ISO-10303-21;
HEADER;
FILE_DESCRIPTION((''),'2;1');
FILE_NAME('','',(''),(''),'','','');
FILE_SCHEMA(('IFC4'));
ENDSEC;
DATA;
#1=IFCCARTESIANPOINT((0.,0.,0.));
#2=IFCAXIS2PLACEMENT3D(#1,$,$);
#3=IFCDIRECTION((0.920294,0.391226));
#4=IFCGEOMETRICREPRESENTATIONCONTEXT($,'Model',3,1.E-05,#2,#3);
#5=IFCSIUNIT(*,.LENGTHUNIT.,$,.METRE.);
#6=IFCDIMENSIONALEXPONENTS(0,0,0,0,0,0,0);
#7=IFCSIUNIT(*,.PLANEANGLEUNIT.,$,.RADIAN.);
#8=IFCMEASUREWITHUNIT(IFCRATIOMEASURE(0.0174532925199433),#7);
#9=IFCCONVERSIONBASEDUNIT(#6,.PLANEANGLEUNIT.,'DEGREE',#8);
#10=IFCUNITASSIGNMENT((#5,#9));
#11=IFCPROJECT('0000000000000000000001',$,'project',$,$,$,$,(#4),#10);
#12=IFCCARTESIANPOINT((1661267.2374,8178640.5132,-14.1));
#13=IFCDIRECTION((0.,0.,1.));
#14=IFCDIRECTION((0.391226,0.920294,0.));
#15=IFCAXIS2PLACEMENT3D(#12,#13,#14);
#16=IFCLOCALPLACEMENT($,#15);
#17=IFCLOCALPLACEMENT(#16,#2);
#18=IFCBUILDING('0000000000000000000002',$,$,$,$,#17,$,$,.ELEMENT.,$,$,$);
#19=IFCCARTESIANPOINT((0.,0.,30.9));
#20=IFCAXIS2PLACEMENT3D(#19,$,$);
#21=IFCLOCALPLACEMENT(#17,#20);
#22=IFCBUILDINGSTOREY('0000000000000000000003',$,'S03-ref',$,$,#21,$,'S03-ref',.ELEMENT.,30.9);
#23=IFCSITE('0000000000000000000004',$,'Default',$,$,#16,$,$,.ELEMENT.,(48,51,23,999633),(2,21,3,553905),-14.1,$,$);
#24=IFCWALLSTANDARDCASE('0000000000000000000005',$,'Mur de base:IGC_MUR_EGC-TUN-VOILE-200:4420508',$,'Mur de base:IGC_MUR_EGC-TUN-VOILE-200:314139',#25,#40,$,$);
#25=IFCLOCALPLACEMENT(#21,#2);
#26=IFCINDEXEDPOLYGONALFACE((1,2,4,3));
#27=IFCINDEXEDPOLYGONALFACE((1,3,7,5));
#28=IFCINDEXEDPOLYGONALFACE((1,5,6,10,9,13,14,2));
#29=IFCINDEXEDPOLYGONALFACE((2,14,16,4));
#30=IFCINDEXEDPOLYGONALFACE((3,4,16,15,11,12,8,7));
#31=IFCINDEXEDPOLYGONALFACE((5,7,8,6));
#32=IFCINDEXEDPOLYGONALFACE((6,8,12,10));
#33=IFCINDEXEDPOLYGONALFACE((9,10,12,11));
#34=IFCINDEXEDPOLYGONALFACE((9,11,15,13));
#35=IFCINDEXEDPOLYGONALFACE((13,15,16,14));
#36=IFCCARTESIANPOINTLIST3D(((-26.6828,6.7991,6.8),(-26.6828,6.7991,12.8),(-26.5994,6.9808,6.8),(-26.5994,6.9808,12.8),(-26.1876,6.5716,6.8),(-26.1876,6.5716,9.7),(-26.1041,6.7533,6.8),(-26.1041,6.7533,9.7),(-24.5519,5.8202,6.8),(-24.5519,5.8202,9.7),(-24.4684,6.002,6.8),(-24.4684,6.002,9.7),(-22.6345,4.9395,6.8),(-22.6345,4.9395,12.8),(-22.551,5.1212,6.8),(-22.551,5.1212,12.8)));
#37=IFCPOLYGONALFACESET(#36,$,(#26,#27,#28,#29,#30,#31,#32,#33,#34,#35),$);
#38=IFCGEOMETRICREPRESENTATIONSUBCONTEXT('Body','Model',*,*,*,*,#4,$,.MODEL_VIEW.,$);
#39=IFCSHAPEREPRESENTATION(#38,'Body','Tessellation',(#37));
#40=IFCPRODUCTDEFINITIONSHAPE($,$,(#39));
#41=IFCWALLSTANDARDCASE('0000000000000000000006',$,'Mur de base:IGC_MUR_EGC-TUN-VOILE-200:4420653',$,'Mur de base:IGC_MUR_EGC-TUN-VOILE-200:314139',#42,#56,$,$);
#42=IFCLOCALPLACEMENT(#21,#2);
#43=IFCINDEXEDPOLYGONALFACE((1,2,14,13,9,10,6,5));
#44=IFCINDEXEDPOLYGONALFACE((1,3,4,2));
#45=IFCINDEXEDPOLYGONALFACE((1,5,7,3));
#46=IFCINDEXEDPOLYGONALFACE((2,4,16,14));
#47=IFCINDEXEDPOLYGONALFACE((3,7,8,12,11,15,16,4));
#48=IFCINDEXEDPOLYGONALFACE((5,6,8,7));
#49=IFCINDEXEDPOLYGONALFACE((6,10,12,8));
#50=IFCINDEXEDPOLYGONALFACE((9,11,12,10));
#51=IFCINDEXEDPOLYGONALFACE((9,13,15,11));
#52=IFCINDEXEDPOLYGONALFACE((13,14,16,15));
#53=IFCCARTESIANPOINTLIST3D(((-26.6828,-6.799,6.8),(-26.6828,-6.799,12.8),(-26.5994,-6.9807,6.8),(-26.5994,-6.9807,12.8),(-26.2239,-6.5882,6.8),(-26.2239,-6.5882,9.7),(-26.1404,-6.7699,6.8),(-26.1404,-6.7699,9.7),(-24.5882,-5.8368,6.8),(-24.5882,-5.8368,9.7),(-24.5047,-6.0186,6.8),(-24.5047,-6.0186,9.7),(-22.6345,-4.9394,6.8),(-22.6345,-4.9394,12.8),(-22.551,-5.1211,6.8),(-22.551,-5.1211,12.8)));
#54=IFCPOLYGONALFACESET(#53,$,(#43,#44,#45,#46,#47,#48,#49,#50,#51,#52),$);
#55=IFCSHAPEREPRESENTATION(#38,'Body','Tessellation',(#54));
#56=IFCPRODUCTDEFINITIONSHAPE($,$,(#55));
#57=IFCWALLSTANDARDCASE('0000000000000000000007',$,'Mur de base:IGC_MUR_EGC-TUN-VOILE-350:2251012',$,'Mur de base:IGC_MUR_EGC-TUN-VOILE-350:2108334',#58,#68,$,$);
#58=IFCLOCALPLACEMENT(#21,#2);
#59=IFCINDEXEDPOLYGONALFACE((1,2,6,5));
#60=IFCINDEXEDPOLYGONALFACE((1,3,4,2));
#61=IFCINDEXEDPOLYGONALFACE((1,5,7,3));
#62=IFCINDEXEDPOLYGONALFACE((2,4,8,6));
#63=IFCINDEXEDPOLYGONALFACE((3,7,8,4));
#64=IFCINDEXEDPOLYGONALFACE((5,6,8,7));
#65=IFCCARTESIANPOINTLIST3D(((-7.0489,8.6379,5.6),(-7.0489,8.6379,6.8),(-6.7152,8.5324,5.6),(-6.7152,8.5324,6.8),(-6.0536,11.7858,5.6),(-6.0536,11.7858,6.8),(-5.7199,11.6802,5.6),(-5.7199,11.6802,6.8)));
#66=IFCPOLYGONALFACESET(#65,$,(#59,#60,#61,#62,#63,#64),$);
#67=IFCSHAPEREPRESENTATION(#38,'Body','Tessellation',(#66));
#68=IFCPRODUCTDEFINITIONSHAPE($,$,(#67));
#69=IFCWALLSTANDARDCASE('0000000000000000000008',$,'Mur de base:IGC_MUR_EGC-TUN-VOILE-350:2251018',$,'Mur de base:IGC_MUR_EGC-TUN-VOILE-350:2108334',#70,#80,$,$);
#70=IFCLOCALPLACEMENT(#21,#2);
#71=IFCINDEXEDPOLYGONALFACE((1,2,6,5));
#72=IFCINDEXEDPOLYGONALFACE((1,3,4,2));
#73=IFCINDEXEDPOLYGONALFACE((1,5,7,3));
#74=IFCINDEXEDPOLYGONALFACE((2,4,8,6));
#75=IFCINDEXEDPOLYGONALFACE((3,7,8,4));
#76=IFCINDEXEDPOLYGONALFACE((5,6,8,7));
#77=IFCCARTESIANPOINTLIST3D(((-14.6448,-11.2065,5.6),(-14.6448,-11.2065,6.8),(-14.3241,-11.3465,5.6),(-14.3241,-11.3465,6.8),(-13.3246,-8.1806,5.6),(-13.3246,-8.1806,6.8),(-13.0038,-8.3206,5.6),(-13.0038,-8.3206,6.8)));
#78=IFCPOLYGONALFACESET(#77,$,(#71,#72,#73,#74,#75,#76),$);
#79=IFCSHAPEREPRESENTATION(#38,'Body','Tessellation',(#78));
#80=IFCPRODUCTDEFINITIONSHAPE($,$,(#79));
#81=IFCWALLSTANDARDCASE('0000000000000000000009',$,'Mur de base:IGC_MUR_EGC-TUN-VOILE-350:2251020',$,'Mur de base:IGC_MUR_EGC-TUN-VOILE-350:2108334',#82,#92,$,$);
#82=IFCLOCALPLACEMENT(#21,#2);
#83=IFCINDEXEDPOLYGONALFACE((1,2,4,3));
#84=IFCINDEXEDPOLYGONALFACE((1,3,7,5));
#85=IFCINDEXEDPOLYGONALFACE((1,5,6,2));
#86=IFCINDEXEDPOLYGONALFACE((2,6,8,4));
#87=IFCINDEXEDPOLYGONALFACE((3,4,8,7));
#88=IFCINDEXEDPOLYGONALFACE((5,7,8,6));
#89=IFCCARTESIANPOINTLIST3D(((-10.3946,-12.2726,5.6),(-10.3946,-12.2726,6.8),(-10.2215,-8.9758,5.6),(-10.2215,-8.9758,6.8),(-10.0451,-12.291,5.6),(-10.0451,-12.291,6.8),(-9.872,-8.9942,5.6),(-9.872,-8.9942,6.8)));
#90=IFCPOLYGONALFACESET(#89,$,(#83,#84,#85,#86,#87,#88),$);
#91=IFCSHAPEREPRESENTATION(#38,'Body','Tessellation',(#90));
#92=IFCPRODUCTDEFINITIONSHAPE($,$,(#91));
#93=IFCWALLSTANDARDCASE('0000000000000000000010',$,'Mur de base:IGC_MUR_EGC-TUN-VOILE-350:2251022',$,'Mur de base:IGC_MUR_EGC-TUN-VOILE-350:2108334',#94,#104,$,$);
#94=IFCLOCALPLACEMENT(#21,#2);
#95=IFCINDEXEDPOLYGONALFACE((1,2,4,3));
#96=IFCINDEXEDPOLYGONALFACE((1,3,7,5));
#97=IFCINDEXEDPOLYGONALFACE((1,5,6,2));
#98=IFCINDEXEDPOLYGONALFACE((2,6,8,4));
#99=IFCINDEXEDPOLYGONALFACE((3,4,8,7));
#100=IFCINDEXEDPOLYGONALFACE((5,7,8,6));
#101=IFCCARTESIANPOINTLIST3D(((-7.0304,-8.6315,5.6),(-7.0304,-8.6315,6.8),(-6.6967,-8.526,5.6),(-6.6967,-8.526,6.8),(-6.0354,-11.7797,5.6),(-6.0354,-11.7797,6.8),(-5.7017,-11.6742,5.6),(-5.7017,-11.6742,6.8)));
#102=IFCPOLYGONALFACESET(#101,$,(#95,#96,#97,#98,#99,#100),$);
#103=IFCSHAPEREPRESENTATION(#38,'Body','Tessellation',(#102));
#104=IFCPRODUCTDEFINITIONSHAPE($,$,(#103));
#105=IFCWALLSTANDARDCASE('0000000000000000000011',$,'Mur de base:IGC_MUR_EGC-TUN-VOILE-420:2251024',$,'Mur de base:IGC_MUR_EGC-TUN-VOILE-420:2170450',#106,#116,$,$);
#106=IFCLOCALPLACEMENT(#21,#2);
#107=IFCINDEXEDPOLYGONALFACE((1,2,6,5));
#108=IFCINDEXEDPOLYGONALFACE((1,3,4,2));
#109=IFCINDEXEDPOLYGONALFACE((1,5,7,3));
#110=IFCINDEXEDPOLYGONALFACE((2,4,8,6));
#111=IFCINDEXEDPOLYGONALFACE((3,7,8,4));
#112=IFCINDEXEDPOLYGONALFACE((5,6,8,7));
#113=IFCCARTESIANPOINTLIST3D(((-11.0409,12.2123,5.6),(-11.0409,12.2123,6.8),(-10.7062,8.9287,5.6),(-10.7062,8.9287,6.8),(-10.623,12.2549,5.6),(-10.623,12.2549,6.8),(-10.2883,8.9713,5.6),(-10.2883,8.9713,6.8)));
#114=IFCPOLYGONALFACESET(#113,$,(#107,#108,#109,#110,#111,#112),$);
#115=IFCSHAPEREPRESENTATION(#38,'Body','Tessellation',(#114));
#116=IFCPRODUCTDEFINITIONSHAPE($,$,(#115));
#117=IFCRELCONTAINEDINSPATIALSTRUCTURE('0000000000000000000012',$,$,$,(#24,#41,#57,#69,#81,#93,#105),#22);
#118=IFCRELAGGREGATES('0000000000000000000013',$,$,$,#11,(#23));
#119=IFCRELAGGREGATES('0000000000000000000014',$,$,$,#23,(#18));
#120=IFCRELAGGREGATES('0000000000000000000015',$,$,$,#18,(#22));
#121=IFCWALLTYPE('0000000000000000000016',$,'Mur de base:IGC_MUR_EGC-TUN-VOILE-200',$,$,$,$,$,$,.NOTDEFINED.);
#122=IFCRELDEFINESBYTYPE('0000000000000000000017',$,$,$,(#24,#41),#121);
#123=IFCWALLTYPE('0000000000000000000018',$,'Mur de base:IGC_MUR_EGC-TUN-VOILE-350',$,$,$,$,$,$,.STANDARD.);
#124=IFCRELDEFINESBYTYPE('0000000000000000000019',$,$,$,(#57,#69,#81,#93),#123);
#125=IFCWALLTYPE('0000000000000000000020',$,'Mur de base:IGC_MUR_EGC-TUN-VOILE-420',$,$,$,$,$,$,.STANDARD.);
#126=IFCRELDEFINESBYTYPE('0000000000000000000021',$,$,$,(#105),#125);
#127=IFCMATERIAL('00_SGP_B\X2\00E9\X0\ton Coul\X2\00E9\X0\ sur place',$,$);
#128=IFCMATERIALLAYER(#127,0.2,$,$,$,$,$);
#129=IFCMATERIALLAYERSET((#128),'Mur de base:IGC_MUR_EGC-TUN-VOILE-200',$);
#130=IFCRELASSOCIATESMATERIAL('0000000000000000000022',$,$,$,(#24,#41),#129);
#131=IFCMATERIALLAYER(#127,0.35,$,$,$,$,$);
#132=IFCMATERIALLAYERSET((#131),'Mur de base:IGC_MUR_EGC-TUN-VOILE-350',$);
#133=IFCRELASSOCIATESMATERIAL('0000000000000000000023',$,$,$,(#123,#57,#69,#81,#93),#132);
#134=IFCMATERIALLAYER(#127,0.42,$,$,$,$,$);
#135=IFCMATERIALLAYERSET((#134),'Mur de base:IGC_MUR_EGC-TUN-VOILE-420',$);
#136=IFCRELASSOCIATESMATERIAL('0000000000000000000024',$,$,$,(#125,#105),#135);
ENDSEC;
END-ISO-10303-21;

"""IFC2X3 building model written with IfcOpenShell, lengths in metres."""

from ifc_helpers import new_model, entity, si_unit, converted_unit, direction, frame, frame_2d, origin, place, context, subcontext, project, spatial, rectangle, extrude, material, layer, layer_set, layer_usage, type_object, element, save


model = new_model("IFC2X3")

# Units and contexts
model_context = context("Model", 3, precision=1e-05, world=origin(), true_north=direction((0.920294, 0.391226)))
body_context = subcontext(model_context, "Body", "Model", "MODEL_VIEW")
ifc_project = project(units=[si_unit("LENGTHUNIT", "METRE"), converted_unit("PLANEANGLEUNIT", "DEGREE", entity("IfcRatioMeasure", 0.0174532925199433), si_unit("PLANEANGLEUNIT", "RADIAN"), dimensions=[0, 0, 0, 0, 0, 0, 0])], contexts=[model_context])

# Site, building, storey
site_placement = place(None, frame((1661267.2374, 8178640.5132, -14.1), z_axis=(0.0, 0.0, 1.0), x_axis=(0.391226, 0.920294, 0.0)))
site = spatial("IfcSite", under=ifc_project, at=site_placement, Name="Default", CompositionType="ELEMENT", RefLatitude=(48, 51, 23, 999633), RefLongitude=(2, 21, 3, 553905), RefElevation=-14.1)
building_placement = place(site_placement, origin())
building = spatial("IfcBuilding", under=site, at=building_placement, CompositionType="ELEMENT")
storey_placement = place(building_placement, frame((0.0, 0.0, 30.9)))
storey = spatial("IfcBuildingStorey", under=building, at=storey_placement, Name="S03-ref", LongName="S03-ref", CompositionType="ELEMENT", Elevation=30.9)

# Shared definitions
ifc_material_1 = material(Name="00_SGP_Béton Coulé sur place")
ifc_layer_1 = layer(ifc_material_1, 0.2)
ifc_layer_set_1 = layer_set([ifc_layer_1], Name="Mur de base:IGC_MUR_EGC-TUN-VOILE-200")
wall_type_1 = type_object("IfcWallType", Name="Mur de base:IGC_MUR_EGC-TUN-VOILE-200", PredefinedType="NOTDEFINED")

# Walls, openings
ifc_layer_usage_1 = layer_usage(ifc_layer_set_1, "AXIS2", "POSITIVE", -0.1)
wall_1_placement = place(storey_placement, frame((-22.5927, 5.0303, 6.8), z_axis=(0.0, 0.0, 1.0), x_axis=(-0.908714, 0.417419, 0.0)))
wall_1 = element("IfcWallStandardCase", 1, at=wall_1_placement, inside=storey, type_object=wall_type_1, material=ifc_layer_usage_1, Name="Mur de base:IGC_MUR_EGC-TUN-VOILE-200:4420508", ObjectType="Mur de base:IGC_MUR_EGC-TUN-VOILE-200:314139", context=body_context, shape_type="SweptSolid", body=[
    extrude(rectangle(XDim=4.455, YDim=0.2, at=frame_2d((2.2275, 0.0), x_axis=(-1.0, 0.0))), origin(), (0.0, 0.0, 1.0), 6.0),
])
opening_1_placement = place(wall_1_placement, origin())
element("IfcOpeningElement", 2, at=opening_1_placement, cuts=wall_1, ObjectType="Opening", context=body_context, shape_type="SweptSolid", body=[
    extrude(rectangle(XDim=2.9, YDim=1.8, at=frame_2d((0.0, 0.0), x_axis=(1.0, 0.0))), frame((3.01, -1.424, 1.45), z_axis=(0.0, 1.0, 0.0), x_axis=(0.0, 0.0, -1.0)), (0.0, 0.0, 1.0), 3.048),
])
ifc_layer_usage_2 = layer_usage(ifc_layer_set_1, "AXIS2", "NEGATIVE", 0.1)
wall_2_placement = place(storey_placement, frame((-22.5927, -5.0302, 6.8), z_axis=(0.0, 0.0, 1.0), x_axis=(-0.908712, -0.417423, 0.0)))
wall_2 = element("IfcWallStandardCase", 3, at=wall_2_placement, inside=storey, type_object=wall_type_1, material=ifc_layer_usage_2, Name="Mur de base:IGC_MUR_EGC-TUN-VOILE-200:4420653", ObjectType="Mur de base:IGC_MUR_EGC-TUN-VOILE-200:314139", context=body_context, shape_type="SweptSolid", body=[
    extrude(rectangle(XDim=4.455, YDim=0.2, at=frame_2d((2.2275, 0.0), x_axis=(-1.0, 0.0))), origin(), (0.0, 0.0, 1.0), 6.0),
])
opening_2_placement = place(wall_2_placement, origin())
element("IfcOpeningElement", 4, at=opening_2_placement, cuts=wall_2, ObjectType="Opening", context=body_context, shape_type="SweptSolid", body=[
    extrude(rectangle(XDim=2.9, YDim=1.8, at=frame_2d((0.0, 0.0), x_axis=(0.0, 1.0))), frame((3.05, -1.624, 1.45), z_axis=(0.0, 1.0, 0.0), x_axis=(1.0, 0.0, 0.0)), (0.0, 0.0, 1.0), 3.048),
])

# Walls
ifc_layer_2 = layer(ifc_material_1, 0.35)
ifc_layer_set_2 = layer_set([ifc_layer_2], Name="Mur de base:IGC_MUR_EGC-TUN-VOILE-350")
ifc_layer_usage_3 = layer_usage(ifc_layer_set_2, "AXIS2", "POSITIVE", -0.175)
wall_type_2 = type_object("IfcWallType", Name="Mur de base:IGC_MUR_EGC-TUN-VOILE-350", PredefinedType="STANDARD", material=ifc_layer_set_2)
wall_3_placement = place(storey_placement, frame((-6.8821, 8.5851, 5.6), z_axis=(0.0, 0.0, 1.0), x_axis=(0.301469, 0.953476, 0.0)))
element("IfcWallStandardCase", 5, at=wall_3_placement, inside=storey, type_object=wall_type_2, material=ifc_layer_usage_3, Name="Mur de base:IGC_MUR_EGC-TUN-VOILE-350:2251012", ObjectType="Mur de base:IGC_MUR_EGC-TUN-VOILE-350:2108334", context=body_context, shape_type="SweptSolid", body=[
    extrude(rectangle(XDim=3.3015, YDim=0.35, at=frame_2d((1.6507, 0.0), x_axis=(-1.0, 0.0))), origin(), (0.0, 0.0, 1.0), 1.2),
])
ifc_layer_usage_4 = layer_usage(ifc_layer_set_2, "AXIS2", "POSITIVE", -0.175)
wall_4_placement = place(storey_placement, frame((-13.1642, -8.2506, 5.6), z_axis=(0.0, 0.0, 1.0), x_axis=(-0.39991, -0.916554, 0.0)))
element("IfcWallStandardCase", 6, at=wall_4_placement, inside=storey, type_object=wall_type_2, material=ifc_layer_usage_4, Name="Mur de base:IGC_MUR_EGC-TUN-VOILE-350:2251018", ObjectType="Mur de base:IGC_MUR_EGC-TUN-VOILE-350:2108334", context=body_context, shape_type="SweptSolid", body=[
    extrude(rectangle(XDim=3.3014, YDim=0.35, at=frame_2d((1.6507, 0.0), x_axis=(-1.0, 0.0))), origin(), (0.0, 0.0, 1.0), 1.2),
])
ifc_layer_usage_5 = layer_usage(ifc_layer_set_2, "AXIS2", "POSITIVE", -0.175)
wall_5_placement = place(storey_placement, frame((-10.0468, -8.985, 5.6), z_axis=(0.0, 0.0, 1.0), x_axis=(-0.052435, -0.998624, 0.0)))
element("IfcWallStandardCase", 7, at=wall_5_placement, inside=storey, type_object=wall_type_2, material=ifc_layer_usage_5, Name="Mur de base:IGC_MUR_EGC-TUN-VOILE-350:2251020", ObjectType="Mur de base:IGC_MUR_EGC-TUN-VOILE-350:2108334", context=body_context, shape_type="SweptSolid", body=[
    extrude(rectangle(XDim=3.3014, YDim=0.35, at=frame_2d((1.6507, 0.0), x_axis=(-1.0, 0.0))), origin(), (0.0, 0.0, 1.0), 1.2),
])
ifc_layer_usage_6 = layer_usage(ifc_layer_set_2, "AXIS2", "POSITIVE", -0.175)
wall_6_placement = place(storey_placement, frame((-6.8636, -8.5787, 5.6), z_axis=(0.0, 0.0, 1.0), x_axis=(0.301365, -0.953509, 0.0)))
element("IfcWallStandardCase", 8, at=wall_6_placement, inside=storey, type_object=wall_type_2, material=ifc_layer_usage_6, Name="Mur de base:IGC_MUR_EGC-TUN-VOILE-350:2251022", ObjectType="Mur de base:IGC_MUR_EGC-TUN-VOILE-350:2108334", context=body_context, shape_type="SweptSolid", body=[
    extrude(rectangle(XDim=3.3017, YDim=0.35, at=frame_2d((1.6508, 0.0), x_axis=(-1.0, 0.0))), origin(), (0.0, 0.0, 1.0), 1.2),
])
ifc_layer_3 = layer(ifc_material_1, 0.42)
ifc_layer_set_3 = layer_set([ifc_layer_3], Name="Mur de base:IGC_MUR_EGC-TUN-VOILE-420")
ifc_layer_usage_7 = layer_usage(ifc_layer_set_3, "AXIS2", "POSITIVE", -0.21)
wall_type_3 = type_object("IfcWallType", Name="Mur de base:IGC_MUR_EGC-TUN-VOILE-420", PredefinedType="STANDARD", material=ifc_layer_set_3)
wall_7_placement = place(storey_placement, frame((-10.4973, 8.95, 5.6), z_axis=(0.0, 0.0, 1.0), x_axis=(-0.101398, 0.994846, 0.0)))
element("IfcWallStandardCase", 9, at=wall_7_placement, inside=storey, type_object=wall_type_3, material=ifc_layer_usage_7, Name="Mur de base:IGC_MUR_EGC-TUN-VOILE-420:2251024", ObjectType="Mur de base:IGC_MUR_EGC-TUN-VOILE-420:2170450", context=body_context, shape_type="SweptSolid", body=[
    extrude(rectangle(XDim=3.3006, YDim=0.42, at=frame_2d((1.6503, 0.0), x_axis=(-1.0, 0.0))), origin(), (0.0, 0.0, 1.0), 1.2),
])

save(model, "model.ifc")
